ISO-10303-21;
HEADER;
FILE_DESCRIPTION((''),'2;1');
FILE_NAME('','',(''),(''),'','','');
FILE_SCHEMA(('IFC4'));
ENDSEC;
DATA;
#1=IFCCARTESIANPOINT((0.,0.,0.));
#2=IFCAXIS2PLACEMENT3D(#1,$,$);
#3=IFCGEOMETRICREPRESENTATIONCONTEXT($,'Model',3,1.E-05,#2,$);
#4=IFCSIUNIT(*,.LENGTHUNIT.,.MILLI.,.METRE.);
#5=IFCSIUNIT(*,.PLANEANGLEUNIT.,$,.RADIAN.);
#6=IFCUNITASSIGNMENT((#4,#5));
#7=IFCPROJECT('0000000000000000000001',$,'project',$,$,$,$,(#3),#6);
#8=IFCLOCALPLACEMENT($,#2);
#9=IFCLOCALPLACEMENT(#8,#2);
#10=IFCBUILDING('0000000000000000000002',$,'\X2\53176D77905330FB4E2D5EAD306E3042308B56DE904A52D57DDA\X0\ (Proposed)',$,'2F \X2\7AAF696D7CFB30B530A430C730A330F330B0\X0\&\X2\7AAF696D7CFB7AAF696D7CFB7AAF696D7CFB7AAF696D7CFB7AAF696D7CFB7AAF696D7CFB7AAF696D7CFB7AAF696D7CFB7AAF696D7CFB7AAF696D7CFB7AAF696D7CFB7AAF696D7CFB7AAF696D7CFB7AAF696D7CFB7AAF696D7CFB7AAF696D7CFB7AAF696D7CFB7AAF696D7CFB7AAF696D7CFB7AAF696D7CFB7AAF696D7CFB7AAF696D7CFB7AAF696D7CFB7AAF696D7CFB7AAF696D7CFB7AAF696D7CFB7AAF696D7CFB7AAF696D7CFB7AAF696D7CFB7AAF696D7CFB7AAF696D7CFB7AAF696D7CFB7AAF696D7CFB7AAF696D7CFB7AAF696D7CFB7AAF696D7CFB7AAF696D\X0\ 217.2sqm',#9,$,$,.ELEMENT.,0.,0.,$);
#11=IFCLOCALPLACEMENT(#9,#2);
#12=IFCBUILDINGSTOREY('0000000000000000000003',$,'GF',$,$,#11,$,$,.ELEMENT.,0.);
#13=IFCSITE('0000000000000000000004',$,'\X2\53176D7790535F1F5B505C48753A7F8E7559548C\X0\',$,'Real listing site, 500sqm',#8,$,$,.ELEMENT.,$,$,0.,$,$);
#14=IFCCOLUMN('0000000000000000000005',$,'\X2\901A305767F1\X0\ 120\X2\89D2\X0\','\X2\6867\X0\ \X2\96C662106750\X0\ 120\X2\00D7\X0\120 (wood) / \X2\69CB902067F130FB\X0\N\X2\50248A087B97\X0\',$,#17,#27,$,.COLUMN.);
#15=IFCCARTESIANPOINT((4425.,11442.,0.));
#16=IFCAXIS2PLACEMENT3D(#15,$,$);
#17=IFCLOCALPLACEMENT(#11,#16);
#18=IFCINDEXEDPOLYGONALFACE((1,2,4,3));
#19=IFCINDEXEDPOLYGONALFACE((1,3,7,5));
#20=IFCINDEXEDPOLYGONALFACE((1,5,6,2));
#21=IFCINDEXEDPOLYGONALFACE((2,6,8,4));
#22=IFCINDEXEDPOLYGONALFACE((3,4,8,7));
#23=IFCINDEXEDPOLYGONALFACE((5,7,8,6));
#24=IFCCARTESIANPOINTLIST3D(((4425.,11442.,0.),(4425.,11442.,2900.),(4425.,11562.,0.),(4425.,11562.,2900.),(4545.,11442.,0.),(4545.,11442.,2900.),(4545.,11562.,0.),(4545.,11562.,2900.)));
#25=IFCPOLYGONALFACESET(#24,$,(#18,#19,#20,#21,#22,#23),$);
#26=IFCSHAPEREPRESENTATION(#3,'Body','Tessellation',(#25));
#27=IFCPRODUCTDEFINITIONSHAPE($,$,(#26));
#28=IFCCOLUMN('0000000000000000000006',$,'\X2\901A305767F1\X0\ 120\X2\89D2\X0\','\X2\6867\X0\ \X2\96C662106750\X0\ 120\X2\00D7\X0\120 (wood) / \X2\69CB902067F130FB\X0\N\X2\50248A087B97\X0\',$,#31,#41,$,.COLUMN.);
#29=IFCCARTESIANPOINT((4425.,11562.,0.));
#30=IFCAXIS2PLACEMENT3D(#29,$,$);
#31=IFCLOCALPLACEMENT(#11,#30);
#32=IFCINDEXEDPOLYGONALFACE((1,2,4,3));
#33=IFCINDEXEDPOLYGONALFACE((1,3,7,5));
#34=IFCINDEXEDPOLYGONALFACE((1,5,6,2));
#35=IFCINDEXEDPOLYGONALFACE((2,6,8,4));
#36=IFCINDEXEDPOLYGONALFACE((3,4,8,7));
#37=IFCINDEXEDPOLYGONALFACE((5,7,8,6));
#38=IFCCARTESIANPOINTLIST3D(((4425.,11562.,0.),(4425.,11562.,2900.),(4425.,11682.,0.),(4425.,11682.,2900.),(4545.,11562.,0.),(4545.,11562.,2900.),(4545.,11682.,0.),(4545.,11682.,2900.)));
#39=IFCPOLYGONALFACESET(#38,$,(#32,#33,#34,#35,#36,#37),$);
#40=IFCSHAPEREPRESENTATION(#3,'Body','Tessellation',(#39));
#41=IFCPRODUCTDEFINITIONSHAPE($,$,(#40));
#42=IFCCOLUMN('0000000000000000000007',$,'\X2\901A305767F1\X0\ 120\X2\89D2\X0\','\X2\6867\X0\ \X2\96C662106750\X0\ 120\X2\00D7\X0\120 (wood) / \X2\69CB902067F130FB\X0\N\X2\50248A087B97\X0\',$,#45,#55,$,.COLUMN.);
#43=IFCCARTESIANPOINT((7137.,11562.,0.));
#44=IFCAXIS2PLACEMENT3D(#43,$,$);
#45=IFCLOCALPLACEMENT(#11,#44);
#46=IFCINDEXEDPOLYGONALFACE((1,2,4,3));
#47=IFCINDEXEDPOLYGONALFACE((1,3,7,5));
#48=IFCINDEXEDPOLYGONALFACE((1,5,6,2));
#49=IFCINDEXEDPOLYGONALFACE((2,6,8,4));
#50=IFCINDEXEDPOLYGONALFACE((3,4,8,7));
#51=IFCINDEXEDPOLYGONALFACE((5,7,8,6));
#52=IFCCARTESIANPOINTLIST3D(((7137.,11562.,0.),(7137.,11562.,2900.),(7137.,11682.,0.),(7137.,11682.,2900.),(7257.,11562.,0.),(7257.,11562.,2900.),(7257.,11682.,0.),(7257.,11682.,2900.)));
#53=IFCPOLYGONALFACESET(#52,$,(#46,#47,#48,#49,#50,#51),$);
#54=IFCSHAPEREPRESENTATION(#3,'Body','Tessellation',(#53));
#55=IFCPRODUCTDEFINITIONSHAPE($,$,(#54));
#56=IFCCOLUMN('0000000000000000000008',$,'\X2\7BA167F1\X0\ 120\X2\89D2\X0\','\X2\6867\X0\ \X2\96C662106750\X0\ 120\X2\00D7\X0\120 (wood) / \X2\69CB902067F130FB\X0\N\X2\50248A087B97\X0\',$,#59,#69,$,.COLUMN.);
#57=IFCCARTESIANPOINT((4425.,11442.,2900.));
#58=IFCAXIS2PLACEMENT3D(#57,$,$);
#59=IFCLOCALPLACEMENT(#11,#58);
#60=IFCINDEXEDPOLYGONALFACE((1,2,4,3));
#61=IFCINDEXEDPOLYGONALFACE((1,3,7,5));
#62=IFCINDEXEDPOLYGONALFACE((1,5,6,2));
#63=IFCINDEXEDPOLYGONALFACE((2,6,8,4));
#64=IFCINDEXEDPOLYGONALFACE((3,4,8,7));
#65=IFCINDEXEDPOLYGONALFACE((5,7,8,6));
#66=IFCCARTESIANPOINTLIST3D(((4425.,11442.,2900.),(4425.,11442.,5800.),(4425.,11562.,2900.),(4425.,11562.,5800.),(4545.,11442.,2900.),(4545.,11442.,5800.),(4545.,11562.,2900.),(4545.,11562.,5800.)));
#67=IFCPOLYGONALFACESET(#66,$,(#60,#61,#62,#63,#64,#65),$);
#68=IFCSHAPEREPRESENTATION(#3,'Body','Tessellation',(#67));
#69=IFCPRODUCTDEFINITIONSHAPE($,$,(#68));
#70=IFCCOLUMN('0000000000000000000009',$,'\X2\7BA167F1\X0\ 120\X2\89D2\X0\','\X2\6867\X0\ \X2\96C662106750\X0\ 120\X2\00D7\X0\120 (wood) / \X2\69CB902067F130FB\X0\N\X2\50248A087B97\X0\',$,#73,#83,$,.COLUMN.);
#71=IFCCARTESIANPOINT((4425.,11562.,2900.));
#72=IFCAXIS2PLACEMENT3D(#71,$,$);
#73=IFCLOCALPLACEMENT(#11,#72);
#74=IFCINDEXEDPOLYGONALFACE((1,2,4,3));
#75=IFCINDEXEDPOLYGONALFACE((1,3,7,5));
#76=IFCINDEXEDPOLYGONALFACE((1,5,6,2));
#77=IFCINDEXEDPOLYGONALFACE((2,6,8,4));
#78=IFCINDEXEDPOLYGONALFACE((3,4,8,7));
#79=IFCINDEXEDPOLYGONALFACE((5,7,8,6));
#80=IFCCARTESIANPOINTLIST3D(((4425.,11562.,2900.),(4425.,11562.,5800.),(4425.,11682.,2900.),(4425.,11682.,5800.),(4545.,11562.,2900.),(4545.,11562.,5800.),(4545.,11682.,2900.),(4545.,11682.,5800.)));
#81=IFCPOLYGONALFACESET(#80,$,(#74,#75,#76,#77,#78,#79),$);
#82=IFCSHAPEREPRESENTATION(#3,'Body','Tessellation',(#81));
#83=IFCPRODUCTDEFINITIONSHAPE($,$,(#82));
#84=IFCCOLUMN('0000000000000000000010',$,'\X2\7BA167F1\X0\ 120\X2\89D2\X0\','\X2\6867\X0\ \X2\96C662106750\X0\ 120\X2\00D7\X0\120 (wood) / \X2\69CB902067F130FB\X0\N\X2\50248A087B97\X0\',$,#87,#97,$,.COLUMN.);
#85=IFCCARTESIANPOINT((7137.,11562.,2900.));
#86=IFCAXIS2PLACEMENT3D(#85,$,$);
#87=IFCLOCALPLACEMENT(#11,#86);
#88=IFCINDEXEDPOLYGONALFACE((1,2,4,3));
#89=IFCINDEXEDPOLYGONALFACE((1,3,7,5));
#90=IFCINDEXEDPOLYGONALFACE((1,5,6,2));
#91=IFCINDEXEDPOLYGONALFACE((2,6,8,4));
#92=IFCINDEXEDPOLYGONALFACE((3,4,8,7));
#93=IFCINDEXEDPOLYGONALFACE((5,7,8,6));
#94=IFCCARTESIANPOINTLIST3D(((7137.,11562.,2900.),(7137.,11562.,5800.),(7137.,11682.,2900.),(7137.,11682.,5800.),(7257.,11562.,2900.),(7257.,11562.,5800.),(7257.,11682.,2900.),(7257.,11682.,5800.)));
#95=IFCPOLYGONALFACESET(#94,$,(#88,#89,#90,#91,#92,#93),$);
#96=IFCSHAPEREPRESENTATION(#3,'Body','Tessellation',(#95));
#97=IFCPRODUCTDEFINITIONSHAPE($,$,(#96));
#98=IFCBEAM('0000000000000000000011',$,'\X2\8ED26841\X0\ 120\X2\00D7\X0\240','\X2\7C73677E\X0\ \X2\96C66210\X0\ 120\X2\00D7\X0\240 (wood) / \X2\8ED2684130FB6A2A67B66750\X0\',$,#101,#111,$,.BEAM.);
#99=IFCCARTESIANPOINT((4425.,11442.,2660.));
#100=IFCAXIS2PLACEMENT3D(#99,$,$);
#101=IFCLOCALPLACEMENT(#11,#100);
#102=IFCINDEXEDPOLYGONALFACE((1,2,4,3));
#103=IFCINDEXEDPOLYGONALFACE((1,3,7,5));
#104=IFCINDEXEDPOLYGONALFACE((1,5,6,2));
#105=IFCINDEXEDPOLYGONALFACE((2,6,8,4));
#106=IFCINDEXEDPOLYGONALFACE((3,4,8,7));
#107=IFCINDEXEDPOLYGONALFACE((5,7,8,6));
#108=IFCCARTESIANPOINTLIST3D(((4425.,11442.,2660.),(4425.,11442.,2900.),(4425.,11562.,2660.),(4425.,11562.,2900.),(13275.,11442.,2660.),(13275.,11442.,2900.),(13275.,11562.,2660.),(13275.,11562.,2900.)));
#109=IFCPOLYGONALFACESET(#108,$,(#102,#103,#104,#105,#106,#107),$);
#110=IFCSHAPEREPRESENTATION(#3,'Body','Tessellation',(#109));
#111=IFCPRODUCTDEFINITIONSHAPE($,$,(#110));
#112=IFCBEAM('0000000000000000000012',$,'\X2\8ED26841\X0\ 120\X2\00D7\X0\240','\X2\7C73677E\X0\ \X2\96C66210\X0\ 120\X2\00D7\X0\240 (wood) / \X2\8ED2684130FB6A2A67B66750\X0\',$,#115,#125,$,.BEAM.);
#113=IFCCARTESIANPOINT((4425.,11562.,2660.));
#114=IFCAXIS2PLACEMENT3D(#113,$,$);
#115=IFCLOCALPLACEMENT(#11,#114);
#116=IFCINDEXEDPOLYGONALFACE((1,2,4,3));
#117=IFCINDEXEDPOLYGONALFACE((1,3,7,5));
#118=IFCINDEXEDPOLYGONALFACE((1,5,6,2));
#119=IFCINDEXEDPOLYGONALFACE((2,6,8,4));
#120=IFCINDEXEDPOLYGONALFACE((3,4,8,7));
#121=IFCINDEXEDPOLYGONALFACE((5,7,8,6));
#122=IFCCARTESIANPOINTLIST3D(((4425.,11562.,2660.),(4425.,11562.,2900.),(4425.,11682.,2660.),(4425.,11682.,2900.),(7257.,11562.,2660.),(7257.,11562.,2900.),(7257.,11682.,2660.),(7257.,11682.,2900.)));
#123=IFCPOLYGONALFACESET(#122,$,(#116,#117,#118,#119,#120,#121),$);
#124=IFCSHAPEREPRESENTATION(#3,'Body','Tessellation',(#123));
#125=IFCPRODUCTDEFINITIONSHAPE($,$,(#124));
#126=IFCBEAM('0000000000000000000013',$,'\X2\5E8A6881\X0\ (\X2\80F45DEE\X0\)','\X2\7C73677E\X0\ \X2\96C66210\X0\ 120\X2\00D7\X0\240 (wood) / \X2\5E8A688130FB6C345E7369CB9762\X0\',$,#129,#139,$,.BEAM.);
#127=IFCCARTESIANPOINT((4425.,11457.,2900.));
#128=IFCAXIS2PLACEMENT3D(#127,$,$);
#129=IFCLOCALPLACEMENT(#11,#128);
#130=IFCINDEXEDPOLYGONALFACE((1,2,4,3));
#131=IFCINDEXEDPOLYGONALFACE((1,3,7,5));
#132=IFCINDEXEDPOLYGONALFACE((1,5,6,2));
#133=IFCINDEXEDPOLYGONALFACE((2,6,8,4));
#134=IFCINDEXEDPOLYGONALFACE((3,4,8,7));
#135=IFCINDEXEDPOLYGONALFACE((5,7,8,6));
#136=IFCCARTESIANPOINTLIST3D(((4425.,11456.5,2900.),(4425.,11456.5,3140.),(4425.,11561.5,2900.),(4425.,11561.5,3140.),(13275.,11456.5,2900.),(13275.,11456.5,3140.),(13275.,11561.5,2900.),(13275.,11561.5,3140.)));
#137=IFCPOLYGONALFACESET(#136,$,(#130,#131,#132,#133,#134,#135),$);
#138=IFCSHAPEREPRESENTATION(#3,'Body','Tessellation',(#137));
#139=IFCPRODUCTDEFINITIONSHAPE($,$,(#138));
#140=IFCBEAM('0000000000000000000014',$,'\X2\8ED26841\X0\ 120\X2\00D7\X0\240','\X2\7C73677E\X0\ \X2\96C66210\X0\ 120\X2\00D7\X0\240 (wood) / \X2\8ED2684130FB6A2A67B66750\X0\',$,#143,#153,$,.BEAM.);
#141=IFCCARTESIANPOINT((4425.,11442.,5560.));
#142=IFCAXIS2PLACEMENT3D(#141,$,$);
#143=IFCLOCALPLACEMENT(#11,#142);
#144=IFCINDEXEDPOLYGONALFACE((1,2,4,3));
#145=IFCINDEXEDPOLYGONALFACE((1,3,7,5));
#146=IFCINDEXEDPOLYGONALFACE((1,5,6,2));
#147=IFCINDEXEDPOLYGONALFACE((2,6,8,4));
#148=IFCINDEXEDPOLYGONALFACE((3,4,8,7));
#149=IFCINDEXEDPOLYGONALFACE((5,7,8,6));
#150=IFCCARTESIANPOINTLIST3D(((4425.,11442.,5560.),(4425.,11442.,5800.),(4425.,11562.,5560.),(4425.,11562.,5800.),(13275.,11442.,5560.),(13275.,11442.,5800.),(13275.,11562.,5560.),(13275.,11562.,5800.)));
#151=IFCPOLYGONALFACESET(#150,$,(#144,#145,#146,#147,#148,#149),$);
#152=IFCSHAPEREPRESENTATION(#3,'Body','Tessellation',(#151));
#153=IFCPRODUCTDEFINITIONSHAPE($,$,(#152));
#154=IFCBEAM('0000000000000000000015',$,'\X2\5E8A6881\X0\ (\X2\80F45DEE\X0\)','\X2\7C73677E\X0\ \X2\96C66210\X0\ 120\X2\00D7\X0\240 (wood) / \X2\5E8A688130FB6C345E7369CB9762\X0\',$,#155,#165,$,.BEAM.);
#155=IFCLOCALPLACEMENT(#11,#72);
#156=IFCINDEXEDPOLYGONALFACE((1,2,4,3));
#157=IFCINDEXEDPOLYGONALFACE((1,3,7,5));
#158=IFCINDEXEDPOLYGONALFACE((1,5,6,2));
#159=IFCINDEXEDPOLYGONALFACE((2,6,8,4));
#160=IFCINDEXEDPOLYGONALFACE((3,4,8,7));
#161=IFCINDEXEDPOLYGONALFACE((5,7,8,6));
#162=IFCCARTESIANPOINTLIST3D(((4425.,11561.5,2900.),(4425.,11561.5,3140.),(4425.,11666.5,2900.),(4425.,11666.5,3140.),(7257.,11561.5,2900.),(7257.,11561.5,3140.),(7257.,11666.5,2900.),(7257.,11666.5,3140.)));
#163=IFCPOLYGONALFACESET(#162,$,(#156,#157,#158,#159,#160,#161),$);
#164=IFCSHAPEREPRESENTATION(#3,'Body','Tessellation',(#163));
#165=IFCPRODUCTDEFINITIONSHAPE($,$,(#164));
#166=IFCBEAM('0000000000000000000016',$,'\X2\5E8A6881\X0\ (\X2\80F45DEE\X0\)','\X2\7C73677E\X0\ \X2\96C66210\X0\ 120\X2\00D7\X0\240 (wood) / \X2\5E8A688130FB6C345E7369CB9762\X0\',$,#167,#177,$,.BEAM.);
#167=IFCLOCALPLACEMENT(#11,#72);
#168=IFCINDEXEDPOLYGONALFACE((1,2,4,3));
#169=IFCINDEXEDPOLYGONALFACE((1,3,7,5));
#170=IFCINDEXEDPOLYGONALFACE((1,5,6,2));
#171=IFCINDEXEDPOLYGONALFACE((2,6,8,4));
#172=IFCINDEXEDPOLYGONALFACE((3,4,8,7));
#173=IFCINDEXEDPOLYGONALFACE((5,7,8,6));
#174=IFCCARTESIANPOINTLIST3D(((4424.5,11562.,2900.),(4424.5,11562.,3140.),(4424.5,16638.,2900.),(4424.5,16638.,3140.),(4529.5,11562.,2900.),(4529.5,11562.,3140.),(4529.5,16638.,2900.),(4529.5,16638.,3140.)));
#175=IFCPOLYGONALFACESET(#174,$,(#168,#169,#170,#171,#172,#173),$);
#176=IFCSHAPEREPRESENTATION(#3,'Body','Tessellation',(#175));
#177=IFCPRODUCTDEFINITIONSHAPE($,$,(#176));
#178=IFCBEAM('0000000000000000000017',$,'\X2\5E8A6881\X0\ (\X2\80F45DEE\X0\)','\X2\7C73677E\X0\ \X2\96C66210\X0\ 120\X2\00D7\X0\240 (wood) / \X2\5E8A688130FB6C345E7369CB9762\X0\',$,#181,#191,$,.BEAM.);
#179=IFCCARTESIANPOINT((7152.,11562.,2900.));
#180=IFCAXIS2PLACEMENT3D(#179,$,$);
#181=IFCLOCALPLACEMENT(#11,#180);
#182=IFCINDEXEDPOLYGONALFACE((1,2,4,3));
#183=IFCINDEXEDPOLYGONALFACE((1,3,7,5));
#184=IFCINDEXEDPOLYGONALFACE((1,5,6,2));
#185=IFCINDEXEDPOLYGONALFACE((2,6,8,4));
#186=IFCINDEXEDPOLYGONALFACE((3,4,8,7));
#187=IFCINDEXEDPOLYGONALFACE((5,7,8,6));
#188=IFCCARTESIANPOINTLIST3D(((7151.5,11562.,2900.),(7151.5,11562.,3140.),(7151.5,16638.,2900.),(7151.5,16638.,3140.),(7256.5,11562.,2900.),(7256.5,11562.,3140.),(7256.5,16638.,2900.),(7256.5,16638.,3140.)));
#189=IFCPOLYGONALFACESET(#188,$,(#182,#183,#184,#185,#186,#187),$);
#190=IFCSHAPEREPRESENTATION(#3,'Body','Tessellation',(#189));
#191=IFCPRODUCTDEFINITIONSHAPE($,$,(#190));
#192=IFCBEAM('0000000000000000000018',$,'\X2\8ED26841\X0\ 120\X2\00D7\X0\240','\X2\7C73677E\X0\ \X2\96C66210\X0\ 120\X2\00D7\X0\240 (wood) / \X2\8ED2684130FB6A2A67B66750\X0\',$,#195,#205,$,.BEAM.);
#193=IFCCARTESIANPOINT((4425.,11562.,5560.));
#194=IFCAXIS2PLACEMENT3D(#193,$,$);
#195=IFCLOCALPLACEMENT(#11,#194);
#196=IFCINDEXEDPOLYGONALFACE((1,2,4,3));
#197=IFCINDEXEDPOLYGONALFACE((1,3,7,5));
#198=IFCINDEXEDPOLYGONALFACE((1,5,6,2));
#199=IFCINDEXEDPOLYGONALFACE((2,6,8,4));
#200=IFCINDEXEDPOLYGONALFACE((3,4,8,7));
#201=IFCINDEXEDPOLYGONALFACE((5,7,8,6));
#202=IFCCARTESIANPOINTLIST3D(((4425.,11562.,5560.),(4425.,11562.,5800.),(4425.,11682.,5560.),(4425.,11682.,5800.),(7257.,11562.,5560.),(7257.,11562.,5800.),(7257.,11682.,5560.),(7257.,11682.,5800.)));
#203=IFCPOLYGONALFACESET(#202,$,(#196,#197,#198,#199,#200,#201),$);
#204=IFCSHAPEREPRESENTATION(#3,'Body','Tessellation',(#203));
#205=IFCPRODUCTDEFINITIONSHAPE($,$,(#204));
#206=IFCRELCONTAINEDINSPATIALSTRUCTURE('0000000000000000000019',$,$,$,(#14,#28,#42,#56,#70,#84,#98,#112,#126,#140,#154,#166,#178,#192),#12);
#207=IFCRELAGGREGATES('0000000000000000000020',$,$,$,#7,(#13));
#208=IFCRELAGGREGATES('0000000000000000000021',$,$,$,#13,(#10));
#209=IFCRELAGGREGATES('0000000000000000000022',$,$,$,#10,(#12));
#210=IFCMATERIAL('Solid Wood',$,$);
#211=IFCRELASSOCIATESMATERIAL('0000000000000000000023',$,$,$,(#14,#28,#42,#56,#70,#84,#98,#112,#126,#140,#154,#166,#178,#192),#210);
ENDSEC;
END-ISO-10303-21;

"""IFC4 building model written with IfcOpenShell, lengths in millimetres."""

from ifc_helpers import new_model, si_unit, frame, frame_2d, origin, place, context, project, spatial, rectangle, extrude, material, element, save


model = new_model("IFC4")

# Units and contexts
model_context = context("Model", 3, precision=1e-05, world=origin())
ifc_project = project(units=[si_unit("LENGTHUNIT", "METRE", prefix="MILLI"), si_unit("PLANEANGLEUNIT", "RADIAN")], contexts=[model_context])

# Site, building, storey
site_placement = place(None, origin())
site = spatial("IfcSite", under=ifc_project, at=site_placement, Name="北海道弟子屈町美留和", ObjectType="Real listing site, 500sqm", CompositionType="ELEMENT", RefElevation=0.0)
building_placement = place(site_placement, origin())
building = spatial("IfcBuilding", under=site, at=building_placement, Name="北海道・中庭のある回遊動線 (Proposed)", ObjectType="2F 窯業系サイディング&窯業系窯業系窯業系窯業系窯業系窯業系窯業系窯業系窯業系窯業系窯業系窯業系窯業系窯業系窯業系窯業系窯業系窯業系窯業系窯業系窯業系窯業系窯業系窯業系窯業系窯業系窯業系窯業系窯業系窯業系窯業系窯業系窯業系窯業系窯業系窯業系窯業 217.2sqm", CompositionType="ELEMENT", ElevationOfRefHeight=0.0, ElevationOfTerrain=0.0)
storey_placement = place(building_placement, origin())
storey = spatial("IfcBuildingStorey", under=building, at=storey_placement, Name="GF", CompositionType="ELEMENT", Elevation=0.0)

# Columns
ifc_material_1 = material(Name="Solid Wood")
column_1_placement = place(storey_placement, frame((4425.0, 11442.0, 0.0)))
element("IfcColumn", 1, at=column_1_placement, inside=storey, material=ifc_material_1, Name="通し柱 120角", Description="桧 集成材 120×120 (wood) / 構造柱・N値計算", PredefinedType="COLUMN", context=model_context, shape_type="SweptSolid", body=[
    extrude(rectangle(XDim=120.0, YDim=120.0, at=frame_2d((60.0, 60.0))), frame((4425.0, 11442.0, 0.0)), (0.0, 0.0, 1.0), 2900.0),
])
column_2_placement = place(storey_placement, frame((4425.0, 11562.0, 0.0)))
element("IfcColumn", 2, at=column_2_placement, inside=storey, material=ifc_material_1, Name="通し柱 120角", Description="桧 集成材 120×120 (wood) / 構造柱・N値計算", PredefinedType="COLUMN", context=model_context, shape_type="SweptSolid", body=[
    extrude(rectangle(XDim=120.0, YDim=120.0, at=frame_2d((60.0, 60.0))), frame((4425.0, 11562.0, 0.0)), (0.0, 0.0, 1.0), 2900.0),
])
column_3_placement = place(storey_placement, frame((7137.0, 11562.0, 0.0)))
element("IfcColumn", 3, at=column_3_placement, inside=storey, material=ifc_material_1, Name="通し柱 120角", Description="桧 集成材 120×120 (wood) / 構造柱・N値計算", PredefinedType="COLUMN", context=model_context, shape_type="SweptSolid", body=[
    extrude(rectangle(XDim=120.0, YDim=120.0, at=frame_2d((60.0, 60.0))), frame((7137.0, 11562.0, 0.0)), (0.0, 0.0, 1.0), 2900.0),
])
column_4_placement = place(storey_placement, frame((4425.0, 11442.0, 2900.0)))
element("IfcColumn", 4, at=column_4_placement, inside=storey, material=ifc_material_1, Name="管柱 120角", Description="桧 集成材 120×120 (wood) / 構造柱・N値計算", PredefinedType="COLUMN", context=model_context, shape_type="SweptSolid", body=[
    extrude(rectangle(XDim=120.0, YDim=120.0, at=frame_2d((60.0, 60.0))), frame((4425.0, 11442.0, 2900.0)), (0.0, 0.0, 1.0), 2900.0),
])
column_5_placement = place(storey_placement, frame((4425.0, 11562.0, 2900.0)))
element("IfcColumn", 5, at=column_5_placement, inside=storey, material=ifc_material_1, Name="管柱 120角", Description="桧 集成材 120×120 (wood) / 構造柱・N値計算", PredefinedType="COLUMN", context=model_context, shape_type="SweptSolid", body=[
    extrude(rectangle(XDim=120.0, YDim=120.0, at=frame_2d((60.0, 60.0))), frame((4425.0, 11562.0, 2900.0)), (0.0, 0.0, 1.0), 2900.0),
])
column_6_placement = place(storey_placement, frame((7137.0, 11562.0, 2900.0)))
element("IfcColumn", 6, at=column_6_placement, inside=storey, material=ifc_material_1, Name="管柱 120角", Description="桧 集成材 120×120 (wood) / 構造柱・N値計算", PredefinedType="COLUMN", context=model_context, shape_type="SweptSolid", body=[
    extrude(rectangle(XDim=120.0, YDim=120.0, at=frame_2d((60.0, 60.0))), frame((7137.0, 11562.0, 2900.0)), (0.0, 0.0, 1.0), 2900.0),
])

# Beams
beam_1_placement = place(storey_placement, frame((4425.0, 11442.0, 2660.0)))
element("IfcBeam", 7, at=beam_1_placement, inside=storey, material=ifc_material_1, Name="軒桁 120×240", Description="米松 集成 120×240 (wood) / 軒桁・横架材", PredefinedType="BEAM", context=model_context, shape_type="SweptSolid", body=[
    extrude(rectangle(XDim=8850.0, YDim=120.0, at=frame_2d((4425.0, 60.0))), frame((4425.0, 11442.0, 2660.0)), (0.0, 0.0, 1.0), 240.0),
])
beam_2_placement = place(storey_placement, frame((4425.0, 11562.0, 2660.0)))
element("IfcBeam", 8, at=beam_2_placement, inside=storey, material=ifc_material_1, Name="軒桁 120×240", Description="米松 集成 120×240 (wood) / 軒桁・横架材", PredefinedType="BEAM", context=model_context, shape_type="SweptSolid", body=[
    extrude(rectangle(XDim=2832.0, YDim=120.0, at=frame_2d((1416.0, 60.0))), frame((4425.0, 11562.0, 2660.0)), (0.0, 0.0, 1.0), 240.0),
])
beam_3_placement = place(storey_placement, frame((4425.0, 11457.0, 2900.0)))
element("IfcBeam", 9, at=beam_3_placement, inside=storey, material=ifc_material_1, Name="床梁 (胴差)", Description="米松 集成 120×240 (wood) / 床梁・水平構面", PredefinedType="BEAM", context=model_context, shape_type="SweptSolid", body=[
    extrude(rectangle(XDim=8850.0, YDim=105.0, at=frame_2d((4425.0, 52.0))), frame((4425.0, 11457.0, 2900.0)), (0.0, 0.0, 1.0), 240.0),
])
beam_4_placement = place(storey_placement, frame((4425.0, 11442.0, 5560.0)))
element("IfcBeam", 10, at=beam_4_placement, inside=storey, material=ifc_material_1, Name="軒桁 120×240", Description="米松 集成 120×240 (wood) / 軒桁・横架材", PredefinedType="BEAM", context=model_context, shape_type="SweptSolid", body=[
    extrude(rectangle(XDim=8850.0, YDim=120.0, at=frame_2d((4425.0, 60.0))), frame((4425.0, 11442.0, 5560.0)), (0.0, 0.0, 1.0), 240.0),
])
beam_5_placement = place(storey_placement, frame((4425.0, 11562.0, 2900.0)))
element("IfcBeam", 11, at=beam_5_placement, inside=storey, material=ifc_material_1, Name="床梁 (胴差)", Description="米松 集成 120×240 (wood) / 床梁・水平構面", PredefinedType="BEAM", context=model_context, shape_type="SweptSolid", body=[
    extrude(rectangle(XDim=2832.0, YDim=105.0, at=frame_2d((1416.0, 52.0))), frame((4425.0, 11562.0, 2900.0)), (0.0, 0.0, 1.0), 240.0),
])
beam_6_placement = place(storey_placement, frame((4425.0, 11562.0, 2900.0)))
element("IfcBeam", 12, at=beam_6_placement, inside=storey, material=ifc_material_1, Name="床梁 (胴差)", Description="米松 集成 120×240 (wood) / 床梁・水平構面", PredefinedType="BEAM", context=model_context, shape_type="SweptSolid", body=[
    extrude(rectangle(XDim=105.0, YDim=5076.0, at=frame_2d((52.0, 2538.0))), frame((4425.0, 11562.0, 2900.0)), (0.0, 0.0, 1.0), 240.0),
])
beam_7_placement = place(storey_placement, frame((7152.0, 11562.0, 2900.0)))
element("IfcBeam", 13, at=beam_7_placement, inside=storey, material=ifc_material_1, Name="床梁 (胴差)", Description="米松 集成 120×240 (wood) / 床梁・水平構面", PredefinedType="BEAM", context=model_context, shape_type="SweptSolid", body=[
    extrude(rectangle(XDim=105.0, YDim=5076.0, at=frame_2d((52.0, 2538.0))), frame((7152.0, 11562.0, 2900.0)), (0.0, 0.0, 1.0), 240.0),
])
beam_8_placement = place(storey_placement, frame((4425.0, 11562.0, 5560.0)))
element("IfcBeam", 14, at=beam_8_placement, inside=storey, material=ifc_material_1, Name="軒桁 120×240", Description="米松 集成 120×240 (wood) / 軒桁・横架材", PredefinedType="BEAM", context=model_context, shape_type="SweptSolid", body=[
    extrude(rectangle(XDim=2832.0, YDim=120.0, at=frame_2d((1416.0, 60.0))), frame((4425.0, 11562.0, 5560.0)), (0.0, 0.0, 1.0), 240.0),
])

save(model, "model.ifc")
